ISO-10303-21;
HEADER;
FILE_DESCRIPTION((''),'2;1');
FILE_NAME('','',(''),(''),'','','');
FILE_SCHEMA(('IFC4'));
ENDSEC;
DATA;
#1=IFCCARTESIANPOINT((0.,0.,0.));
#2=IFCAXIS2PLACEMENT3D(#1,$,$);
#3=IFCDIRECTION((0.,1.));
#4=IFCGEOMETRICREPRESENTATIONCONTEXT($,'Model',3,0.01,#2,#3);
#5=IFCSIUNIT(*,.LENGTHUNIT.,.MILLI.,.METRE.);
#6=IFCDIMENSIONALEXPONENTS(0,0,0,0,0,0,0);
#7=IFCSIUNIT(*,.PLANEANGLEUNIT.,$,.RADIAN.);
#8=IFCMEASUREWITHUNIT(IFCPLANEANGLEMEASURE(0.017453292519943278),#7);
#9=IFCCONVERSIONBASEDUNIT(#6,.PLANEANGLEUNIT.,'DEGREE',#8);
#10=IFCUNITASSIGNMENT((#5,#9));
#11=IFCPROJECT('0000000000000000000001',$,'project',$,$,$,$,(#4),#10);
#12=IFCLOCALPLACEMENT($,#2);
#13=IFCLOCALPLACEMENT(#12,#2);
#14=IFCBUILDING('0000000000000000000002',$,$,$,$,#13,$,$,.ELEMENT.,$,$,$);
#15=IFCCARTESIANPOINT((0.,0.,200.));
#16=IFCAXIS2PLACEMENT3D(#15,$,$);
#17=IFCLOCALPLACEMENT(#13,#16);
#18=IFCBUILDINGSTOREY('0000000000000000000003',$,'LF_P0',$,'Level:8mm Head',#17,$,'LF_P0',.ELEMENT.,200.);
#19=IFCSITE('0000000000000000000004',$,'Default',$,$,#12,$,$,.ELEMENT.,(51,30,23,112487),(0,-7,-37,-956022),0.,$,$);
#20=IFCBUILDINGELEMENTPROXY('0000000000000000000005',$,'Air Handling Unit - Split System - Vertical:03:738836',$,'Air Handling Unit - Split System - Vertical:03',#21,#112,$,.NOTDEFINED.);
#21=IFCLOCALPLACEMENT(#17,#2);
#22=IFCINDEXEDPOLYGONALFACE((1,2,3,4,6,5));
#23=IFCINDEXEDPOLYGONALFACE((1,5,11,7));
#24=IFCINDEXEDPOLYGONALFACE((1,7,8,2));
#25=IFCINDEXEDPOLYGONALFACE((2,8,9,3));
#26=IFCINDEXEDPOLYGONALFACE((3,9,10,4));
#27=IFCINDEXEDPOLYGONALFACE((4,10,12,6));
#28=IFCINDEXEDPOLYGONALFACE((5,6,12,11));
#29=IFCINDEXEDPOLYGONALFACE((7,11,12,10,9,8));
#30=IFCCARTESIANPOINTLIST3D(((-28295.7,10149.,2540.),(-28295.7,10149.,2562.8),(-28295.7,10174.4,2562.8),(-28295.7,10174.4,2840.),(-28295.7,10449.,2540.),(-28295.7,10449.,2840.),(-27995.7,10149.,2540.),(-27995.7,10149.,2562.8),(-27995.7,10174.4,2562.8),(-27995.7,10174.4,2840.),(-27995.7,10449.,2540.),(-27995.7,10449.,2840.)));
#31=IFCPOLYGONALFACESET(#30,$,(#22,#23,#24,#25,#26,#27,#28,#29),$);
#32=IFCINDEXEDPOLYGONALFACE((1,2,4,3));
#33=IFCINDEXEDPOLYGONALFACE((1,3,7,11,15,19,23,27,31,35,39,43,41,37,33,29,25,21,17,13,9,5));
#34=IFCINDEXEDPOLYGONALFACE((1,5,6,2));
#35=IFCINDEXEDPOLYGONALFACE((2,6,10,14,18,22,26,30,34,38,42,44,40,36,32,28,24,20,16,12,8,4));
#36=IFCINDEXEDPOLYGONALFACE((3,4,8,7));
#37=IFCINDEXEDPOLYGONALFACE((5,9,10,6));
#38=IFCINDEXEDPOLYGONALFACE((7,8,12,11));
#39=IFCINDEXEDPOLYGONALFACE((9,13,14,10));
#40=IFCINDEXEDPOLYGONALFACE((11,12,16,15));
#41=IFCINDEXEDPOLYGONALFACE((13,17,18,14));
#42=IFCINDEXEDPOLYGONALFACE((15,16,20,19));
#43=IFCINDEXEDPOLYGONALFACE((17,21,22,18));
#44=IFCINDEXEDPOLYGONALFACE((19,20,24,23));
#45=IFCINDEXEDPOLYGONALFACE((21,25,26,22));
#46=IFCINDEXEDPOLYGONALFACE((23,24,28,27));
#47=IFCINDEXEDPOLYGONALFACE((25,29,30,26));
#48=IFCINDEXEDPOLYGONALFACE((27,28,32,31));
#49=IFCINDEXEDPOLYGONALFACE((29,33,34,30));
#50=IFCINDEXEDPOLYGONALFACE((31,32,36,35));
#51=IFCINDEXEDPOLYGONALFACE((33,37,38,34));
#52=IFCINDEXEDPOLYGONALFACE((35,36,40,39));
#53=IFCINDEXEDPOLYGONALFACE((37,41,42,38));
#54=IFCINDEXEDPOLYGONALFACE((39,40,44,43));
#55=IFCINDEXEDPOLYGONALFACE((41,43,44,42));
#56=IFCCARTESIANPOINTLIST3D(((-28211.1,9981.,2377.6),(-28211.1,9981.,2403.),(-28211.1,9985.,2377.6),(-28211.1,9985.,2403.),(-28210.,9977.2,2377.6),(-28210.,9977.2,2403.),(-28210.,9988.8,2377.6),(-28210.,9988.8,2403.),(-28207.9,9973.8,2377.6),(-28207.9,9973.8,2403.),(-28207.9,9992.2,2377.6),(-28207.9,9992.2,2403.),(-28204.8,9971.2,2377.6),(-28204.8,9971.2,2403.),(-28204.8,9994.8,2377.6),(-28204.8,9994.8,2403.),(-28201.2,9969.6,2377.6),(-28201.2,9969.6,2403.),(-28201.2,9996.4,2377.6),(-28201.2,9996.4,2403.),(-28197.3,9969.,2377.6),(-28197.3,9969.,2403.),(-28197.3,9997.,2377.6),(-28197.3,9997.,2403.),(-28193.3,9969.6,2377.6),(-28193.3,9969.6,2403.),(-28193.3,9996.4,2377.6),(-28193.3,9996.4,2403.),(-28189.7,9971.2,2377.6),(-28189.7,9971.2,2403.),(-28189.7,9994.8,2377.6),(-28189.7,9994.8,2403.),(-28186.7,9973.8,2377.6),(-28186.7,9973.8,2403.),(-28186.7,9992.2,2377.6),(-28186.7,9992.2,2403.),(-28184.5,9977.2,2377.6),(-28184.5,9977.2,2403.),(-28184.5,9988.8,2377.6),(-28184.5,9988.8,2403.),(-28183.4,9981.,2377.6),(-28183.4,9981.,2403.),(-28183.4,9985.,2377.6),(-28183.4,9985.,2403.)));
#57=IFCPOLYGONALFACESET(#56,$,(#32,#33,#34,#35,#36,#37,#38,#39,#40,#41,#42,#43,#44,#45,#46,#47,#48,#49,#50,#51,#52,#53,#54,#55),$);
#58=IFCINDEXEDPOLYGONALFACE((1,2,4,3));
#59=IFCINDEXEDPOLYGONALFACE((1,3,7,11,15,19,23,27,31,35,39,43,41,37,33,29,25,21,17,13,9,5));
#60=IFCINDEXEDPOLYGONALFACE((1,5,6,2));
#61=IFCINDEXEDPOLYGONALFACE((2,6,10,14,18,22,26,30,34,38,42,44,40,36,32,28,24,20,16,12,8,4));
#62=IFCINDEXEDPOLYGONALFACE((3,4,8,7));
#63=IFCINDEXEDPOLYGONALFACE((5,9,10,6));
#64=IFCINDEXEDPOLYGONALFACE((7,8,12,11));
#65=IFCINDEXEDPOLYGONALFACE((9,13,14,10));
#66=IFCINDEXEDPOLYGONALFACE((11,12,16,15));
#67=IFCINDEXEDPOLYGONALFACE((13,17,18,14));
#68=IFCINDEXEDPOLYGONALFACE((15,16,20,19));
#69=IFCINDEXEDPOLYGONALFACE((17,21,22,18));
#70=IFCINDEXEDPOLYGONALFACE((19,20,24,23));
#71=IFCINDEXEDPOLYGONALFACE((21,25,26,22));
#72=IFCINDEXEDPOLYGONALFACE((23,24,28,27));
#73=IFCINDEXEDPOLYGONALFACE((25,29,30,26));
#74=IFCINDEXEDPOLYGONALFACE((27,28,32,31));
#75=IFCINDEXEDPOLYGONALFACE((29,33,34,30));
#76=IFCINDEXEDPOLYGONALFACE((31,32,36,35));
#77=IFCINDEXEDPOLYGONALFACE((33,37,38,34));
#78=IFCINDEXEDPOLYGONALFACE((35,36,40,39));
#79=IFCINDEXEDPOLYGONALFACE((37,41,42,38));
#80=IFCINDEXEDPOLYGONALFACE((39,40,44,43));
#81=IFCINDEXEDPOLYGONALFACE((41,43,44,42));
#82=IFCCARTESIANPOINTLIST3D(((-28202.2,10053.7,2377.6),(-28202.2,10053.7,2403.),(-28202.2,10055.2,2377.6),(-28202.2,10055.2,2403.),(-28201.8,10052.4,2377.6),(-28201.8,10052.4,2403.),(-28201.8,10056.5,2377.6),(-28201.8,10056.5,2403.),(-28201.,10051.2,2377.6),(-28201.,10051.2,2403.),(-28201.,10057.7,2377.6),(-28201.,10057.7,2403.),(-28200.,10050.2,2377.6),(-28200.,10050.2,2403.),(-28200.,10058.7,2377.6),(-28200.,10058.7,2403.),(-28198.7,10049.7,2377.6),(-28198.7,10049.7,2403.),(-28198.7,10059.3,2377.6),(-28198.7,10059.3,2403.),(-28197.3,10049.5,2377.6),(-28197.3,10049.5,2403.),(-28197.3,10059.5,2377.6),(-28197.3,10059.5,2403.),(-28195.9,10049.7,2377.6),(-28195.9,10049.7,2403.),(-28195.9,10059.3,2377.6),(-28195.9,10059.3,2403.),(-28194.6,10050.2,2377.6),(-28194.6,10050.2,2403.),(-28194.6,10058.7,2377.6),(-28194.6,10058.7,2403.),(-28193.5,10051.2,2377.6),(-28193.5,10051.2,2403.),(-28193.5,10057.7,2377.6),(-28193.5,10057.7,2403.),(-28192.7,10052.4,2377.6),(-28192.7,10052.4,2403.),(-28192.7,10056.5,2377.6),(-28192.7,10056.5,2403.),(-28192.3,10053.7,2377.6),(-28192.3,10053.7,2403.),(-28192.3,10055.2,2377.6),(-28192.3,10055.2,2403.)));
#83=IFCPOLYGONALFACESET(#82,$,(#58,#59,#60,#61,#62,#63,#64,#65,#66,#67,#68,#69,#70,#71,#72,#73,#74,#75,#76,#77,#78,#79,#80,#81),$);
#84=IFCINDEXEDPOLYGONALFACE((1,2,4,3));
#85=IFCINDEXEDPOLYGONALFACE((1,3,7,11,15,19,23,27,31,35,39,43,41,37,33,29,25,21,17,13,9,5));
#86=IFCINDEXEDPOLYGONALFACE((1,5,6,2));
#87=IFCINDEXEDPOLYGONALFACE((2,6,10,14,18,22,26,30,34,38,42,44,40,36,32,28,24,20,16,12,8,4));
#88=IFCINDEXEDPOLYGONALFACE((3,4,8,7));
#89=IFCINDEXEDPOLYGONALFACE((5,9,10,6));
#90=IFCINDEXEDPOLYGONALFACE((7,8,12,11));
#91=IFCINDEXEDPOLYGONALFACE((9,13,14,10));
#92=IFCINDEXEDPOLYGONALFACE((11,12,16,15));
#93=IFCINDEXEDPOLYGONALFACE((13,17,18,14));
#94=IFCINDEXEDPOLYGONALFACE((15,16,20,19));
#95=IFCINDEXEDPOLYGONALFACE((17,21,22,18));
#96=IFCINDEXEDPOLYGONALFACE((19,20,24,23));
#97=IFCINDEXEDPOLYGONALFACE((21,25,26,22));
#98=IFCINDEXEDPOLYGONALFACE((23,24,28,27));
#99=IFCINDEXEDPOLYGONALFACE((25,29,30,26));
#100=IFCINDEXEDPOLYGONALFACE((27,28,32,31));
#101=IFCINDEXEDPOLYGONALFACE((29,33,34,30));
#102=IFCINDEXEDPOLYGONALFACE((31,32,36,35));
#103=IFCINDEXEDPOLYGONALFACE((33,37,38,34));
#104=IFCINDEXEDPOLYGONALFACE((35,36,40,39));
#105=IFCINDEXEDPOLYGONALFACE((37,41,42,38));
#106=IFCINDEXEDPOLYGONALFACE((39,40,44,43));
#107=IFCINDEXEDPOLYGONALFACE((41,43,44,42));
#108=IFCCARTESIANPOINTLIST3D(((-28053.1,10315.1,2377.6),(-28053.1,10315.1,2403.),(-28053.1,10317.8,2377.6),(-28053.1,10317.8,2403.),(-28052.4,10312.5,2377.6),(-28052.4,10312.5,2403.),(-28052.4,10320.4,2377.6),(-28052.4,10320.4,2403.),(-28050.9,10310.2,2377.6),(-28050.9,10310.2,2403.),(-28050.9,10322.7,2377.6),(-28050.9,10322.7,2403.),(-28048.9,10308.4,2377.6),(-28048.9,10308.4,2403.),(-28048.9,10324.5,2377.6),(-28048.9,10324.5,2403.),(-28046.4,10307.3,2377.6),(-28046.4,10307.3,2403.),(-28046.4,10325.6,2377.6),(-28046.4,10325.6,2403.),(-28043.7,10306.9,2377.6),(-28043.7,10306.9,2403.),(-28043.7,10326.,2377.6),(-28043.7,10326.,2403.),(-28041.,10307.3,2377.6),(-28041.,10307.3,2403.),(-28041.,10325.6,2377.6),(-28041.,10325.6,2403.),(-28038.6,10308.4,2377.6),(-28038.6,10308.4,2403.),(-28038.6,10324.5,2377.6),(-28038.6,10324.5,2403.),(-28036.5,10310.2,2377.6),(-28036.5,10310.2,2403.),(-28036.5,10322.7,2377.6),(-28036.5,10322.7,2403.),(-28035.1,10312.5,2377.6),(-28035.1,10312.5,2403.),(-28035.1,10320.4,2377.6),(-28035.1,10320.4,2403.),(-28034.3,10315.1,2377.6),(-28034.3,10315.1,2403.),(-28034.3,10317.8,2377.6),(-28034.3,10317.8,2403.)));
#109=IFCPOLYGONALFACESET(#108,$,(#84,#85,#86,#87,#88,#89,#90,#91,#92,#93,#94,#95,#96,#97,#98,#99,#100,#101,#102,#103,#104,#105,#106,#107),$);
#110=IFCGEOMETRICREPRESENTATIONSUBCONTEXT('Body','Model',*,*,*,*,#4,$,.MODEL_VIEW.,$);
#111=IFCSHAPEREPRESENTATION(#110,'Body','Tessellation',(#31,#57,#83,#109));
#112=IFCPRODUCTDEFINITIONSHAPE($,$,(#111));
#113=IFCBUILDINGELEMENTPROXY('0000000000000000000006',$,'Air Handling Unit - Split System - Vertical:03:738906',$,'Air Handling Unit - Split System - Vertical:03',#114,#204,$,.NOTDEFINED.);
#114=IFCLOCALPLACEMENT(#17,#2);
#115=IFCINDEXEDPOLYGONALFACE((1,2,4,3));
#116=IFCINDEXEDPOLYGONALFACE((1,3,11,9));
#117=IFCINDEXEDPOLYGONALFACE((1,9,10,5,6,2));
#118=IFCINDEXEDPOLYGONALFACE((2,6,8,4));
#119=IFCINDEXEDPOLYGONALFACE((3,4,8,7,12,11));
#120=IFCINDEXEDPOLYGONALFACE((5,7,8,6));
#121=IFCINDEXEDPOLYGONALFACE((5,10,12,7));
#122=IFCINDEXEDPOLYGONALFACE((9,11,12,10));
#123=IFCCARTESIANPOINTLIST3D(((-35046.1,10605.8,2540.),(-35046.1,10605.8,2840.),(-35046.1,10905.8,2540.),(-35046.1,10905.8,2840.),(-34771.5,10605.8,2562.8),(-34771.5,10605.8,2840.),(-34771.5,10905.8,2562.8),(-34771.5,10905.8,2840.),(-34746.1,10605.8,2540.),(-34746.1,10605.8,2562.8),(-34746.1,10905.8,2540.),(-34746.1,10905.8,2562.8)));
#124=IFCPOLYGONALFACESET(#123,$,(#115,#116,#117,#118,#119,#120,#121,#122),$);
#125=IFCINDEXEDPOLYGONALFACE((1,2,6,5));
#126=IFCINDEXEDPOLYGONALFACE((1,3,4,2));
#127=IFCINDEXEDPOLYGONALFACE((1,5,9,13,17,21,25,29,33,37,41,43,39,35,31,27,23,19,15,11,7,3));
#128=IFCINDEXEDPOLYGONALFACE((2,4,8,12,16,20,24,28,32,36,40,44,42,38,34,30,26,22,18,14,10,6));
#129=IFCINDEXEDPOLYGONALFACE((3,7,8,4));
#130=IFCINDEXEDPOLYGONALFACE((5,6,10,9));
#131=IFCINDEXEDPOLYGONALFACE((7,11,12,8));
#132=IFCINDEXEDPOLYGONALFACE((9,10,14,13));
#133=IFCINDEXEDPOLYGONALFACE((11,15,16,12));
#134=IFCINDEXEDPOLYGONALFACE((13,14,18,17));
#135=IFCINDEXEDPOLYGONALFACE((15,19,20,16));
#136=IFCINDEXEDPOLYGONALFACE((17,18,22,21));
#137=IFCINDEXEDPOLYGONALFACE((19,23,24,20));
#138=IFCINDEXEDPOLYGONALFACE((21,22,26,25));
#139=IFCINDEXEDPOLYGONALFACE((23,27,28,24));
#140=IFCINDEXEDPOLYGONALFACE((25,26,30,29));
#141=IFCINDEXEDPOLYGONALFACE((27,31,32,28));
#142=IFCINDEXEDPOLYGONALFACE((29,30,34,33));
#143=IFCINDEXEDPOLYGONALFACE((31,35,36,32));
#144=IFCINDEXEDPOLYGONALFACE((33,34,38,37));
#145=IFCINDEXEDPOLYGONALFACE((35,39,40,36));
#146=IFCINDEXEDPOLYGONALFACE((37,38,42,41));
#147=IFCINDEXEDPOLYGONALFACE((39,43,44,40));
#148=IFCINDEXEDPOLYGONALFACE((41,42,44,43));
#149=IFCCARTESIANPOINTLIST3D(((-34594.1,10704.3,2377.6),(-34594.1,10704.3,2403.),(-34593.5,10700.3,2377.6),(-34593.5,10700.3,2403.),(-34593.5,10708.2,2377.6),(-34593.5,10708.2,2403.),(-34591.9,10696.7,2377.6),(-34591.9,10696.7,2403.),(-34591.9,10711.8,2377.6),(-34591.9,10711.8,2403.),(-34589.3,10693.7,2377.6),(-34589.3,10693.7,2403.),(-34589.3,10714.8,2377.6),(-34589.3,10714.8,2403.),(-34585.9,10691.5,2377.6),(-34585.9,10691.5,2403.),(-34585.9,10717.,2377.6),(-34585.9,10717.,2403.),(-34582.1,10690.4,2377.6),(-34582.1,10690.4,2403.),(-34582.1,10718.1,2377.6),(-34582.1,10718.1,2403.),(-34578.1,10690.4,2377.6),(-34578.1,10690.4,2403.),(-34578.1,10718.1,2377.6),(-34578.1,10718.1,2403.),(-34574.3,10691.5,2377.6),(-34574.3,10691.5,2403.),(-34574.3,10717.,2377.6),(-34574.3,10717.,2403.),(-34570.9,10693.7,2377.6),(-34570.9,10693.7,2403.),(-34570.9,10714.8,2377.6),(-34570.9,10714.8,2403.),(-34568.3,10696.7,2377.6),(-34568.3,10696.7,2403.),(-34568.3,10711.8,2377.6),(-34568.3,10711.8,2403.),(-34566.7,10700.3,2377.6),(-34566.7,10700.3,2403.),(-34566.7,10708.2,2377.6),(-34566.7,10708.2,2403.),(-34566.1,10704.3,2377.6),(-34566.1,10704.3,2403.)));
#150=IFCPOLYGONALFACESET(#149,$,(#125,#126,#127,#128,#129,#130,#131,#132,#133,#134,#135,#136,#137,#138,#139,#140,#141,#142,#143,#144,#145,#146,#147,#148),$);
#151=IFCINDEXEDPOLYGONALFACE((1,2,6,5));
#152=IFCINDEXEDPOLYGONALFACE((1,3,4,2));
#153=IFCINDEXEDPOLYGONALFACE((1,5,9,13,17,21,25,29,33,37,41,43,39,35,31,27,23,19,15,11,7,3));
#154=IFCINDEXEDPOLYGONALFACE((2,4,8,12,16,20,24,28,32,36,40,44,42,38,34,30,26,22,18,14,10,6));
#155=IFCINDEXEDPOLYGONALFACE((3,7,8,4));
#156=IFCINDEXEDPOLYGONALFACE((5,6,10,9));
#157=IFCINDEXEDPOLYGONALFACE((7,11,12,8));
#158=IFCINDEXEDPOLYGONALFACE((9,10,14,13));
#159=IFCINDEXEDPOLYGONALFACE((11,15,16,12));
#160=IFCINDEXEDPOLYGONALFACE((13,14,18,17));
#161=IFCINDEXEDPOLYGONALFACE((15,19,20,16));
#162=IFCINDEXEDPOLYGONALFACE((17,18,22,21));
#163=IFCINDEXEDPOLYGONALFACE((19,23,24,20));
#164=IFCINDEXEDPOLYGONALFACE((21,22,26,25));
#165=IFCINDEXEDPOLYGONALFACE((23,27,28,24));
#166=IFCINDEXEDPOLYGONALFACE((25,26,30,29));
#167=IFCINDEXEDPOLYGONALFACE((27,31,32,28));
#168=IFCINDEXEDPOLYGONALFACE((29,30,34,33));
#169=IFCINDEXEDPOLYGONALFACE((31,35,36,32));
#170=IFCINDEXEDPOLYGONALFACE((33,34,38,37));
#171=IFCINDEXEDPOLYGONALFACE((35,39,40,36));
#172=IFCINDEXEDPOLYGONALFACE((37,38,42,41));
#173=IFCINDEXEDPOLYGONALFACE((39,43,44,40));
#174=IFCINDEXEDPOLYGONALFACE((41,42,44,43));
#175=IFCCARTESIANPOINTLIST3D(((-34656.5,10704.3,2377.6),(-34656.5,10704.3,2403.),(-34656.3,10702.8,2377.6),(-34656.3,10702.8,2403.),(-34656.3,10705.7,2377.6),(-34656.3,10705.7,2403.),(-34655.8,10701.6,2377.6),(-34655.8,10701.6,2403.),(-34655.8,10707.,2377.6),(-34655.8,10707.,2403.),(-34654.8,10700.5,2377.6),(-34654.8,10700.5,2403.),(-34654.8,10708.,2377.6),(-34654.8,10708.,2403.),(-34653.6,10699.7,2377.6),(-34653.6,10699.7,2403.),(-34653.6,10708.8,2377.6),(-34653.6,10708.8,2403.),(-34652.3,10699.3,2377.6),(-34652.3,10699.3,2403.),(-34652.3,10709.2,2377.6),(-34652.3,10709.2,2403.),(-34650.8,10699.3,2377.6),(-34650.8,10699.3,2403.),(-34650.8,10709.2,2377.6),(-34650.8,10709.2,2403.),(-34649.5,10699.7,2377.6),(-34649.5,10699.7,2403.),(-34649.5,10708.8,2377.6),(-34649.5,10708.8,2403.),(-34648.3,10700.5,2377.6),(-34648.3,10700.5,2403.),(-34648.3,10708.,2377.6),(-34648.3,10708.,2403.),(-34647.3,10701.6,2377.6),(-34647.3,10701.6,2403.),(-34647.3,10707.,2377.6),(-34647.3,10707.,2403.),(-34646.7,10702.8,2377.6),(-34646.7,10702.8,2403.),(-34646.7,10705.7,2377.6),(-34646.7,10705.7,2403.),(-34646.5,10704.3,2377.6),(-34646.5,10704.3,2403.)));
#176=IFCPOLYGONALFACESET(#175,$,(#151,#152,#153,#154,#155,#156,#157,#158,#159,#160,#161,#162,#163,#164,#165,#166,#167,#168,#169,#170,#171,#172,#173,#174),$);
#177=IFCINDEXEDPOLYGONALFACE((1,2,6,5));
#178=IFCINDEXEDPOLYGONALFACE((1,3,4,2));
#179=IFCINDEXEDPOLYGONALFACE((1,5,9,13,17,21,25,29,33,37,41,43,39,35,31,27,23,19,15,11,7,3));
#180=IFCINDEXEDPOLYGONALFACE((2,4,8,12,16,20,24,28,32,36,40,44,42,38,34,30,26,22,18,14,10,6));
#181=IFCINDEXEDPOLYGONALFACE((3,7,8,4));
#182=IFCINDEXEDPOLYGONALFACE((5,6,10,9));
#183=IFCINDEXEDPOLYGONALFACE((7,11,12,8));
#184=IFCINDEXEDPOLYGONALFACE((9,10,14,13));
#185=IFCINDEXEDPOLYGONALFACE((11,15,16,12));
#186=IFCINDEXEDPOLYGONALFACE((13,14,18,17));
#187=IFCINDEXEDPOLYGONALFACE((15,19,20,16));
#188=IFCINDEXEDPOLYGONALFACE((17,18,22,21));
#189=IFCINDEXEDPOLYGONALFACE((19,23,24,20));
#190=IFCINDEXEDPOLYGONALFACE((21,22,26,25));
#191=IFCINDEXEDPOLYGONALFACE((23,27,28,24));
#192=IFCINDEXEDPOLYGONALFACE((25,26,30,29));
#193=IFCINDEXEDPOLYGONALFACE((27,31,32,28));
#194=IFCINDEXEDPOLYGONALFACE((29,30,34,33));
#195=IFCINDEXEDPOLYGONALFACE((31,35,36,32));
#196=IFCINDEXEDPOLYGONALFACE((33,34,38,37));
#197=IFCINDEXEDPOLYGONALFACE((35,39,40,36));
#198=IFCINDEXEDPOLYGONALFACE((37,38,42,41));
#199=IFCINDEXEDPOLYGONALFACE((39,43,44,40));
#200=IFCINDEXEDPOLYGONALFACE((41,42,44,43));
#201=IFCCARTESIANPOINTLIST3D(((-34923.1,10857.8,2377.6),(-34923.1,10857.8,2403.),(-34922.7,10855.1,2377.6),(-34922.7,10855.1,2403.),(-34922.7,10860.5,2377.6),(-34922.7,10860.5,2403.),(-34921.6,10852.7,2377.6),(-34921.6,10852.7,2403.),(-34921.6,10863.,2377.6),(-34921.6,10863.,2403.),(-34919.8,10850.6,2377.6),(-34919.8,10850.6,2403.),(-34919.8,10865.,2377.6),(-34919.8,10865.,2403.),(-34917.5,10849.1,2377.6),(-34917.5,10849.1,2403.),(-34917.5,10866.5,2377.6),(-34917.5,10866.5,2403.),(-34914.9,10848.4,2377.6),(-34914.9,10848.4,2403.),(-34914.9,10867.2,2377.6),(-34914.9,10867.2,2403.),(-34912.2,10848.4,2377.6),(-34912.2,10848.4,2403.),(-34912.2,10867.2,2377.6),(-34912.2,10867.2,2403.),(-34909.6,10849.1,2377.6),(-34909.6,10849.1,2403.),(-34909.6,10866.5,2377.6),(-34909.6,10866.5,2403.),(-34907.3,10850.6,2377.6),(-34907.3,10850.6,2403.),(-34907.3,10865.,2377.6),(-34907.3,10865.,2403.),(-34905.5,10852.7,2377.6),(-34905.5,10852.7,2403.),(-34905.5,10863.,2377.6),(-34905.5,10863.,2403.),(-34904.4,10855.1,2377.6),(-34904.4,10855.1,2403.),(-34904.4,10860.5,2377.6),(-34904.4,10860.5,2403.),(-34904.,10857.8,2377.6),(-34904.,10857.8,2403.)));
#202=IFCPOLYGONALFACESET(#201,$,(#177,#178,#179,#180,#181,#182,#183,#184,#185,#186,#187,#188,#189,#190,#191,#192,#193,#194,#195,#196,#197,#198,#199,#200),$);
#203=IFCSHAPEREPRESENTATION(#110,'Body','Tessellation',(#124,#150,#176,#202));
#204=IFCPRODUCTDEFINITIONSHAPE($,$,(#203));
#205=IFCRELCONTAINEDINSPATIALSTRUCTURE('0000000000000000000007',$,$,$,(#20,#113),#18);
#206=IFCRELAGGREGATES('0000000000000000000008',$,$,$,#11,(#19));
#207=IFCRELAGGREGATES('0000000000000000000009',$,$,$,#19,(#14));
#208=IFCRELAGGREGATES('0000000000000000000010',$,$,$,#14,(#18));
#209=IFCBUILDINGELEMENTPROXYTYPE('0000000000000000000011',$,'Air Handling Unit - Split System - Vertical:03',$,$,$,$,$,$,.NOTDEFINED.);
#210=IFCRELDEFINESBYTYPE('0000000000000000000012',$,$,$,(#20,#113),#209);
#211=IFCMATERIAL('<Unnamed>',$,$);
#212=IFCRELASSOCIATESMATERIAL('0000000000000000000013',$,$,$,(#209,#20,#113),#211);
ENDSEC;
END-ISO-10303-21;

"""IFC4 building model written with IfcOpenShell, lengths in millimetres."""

from ifc_helpers import new_model, entity, si_unit, converted_unit, direction, frame, origin, place, context, subcontext, project, spatial, arc, indexed_curve, outline, extrude, source, transform, mapped, material, type_object, type_shapes, element, save


model = new_model("IFC4")

# Units and contexts
model_context = context("Model", 3, precision=0.01, world=origin(), true_north=direction((0.0, 1.0)))
body_context = subcontext(model_context, "Body", "Model", "MODEL_VIEW")
ifc_project = project(units=[si_unit("LENGTHUNIT", "METRE", prefix="MILLI"), converted_unit("PLANEANGLEUNIT", "DEGREE", entity("IfcPlaneAngleMeasure", 0.017453292519943278), si_unit("PLANEANGLEUNIT", "RADIAN"), dimensions=[0, 0, 0, 0, 0, 0, 0])], contexts=[model_context])

# Site, building, storey
site_placement = place(None, origin())
site = spatial("IfcSite", under=ifc_project, at=site_placement, Name="Default", CompositionType="ELEMENT", RefLatitude=(51, 30, 23, 112487), RefLongitude=(0, -7, -37, -956022), RefElevation=0.0)
building_placement = place(site_placement, origin())
building = spatial("IfcBuilding", under=site, at=building_placement, CompositionType="ELEMENT")
storey_placement = place(building_placement, frame((0.0, 0.0, 200.0)))
storey = spatial("IfcBuildingStorey", under=building, at=storey_placement, Name="LF_P0", ObjectType="Level:8mm Head", LongName="LF_P0", CompositionType="ELEMENT", Elevation=200.0)

# Shared definitions
ifc_material = material(Name="<Unnamed>")

# Building element proxies
building_element_proxy_type_1 = type_object("IfcBuildingElementProxyType", Name="Air Handling Unit - Split System - Vertical:03", PredefinedType="NOTDEFINED", material=ifc_material)
shared_shape_1 = source(origin(), body_context, "Body", "SweptSolid", [
    extrude(outline(indexed_curve([(-191.5, -107.6), (108.5, -107.6), (108.5, -84.8), (83.1, -84.8), (83.1, 192.4), (-191.5, 192.4), (-191.5, -107.6)], self_intersect=False)), frame((-150.0, 42.4, 191.5), z_axis=(1.0, 0.0, 0.0), x_axis=(0.0, 0.0, 1.0)), (0.0, 0.0, 1.0), 300.0),
    extrude(outline(indexed_curve([(-14.0, 0.0), (0.0, -14.0), (14.0, 0.0), (0.0, 14.0)], segments=[arc(1, 2, 3), arc(3, 4, 1)], self_intersect=False)), frame((51.6, 287.0, 466.0), z_axis=(0.0, 1.0, 0.0), x_axis=(0.0, 0.0, -1.0)), (0.0, 0.0, 1.0), 25.4),
    extrude(outline(indexed_curve([(-5.0, 0.0), (0.0, -5.0), (5.0, 0.0), (0.0, 5.0)], segments=[arc(1, 2, 3), arc(3, 4, 1)], self_intersect=False)), frame((51.6, 287.0, 394.6), z_axis=(0.0, 1.0, 0.0), x_axis=(0.0, 0.0, -1.0)), (0.0, 0.0, 1.0), 25.4),
    extrude(outline(indexed_curve([(-9.5, 0.0), (0.0, -9.5), (9.5, 0.0), (0.0, 9.5)], segments=[arc(1, 2, 3), arc(3, 4, 1)], self_intersect=False)), frame((-102.0, 287.0, 132.6), z_axis=(0.0, 1.0, 0.0), x_axis=(0.0, 0.0, -1.0)), (0.0, 0.0, 1.0), 25.4),
])
type_shapes(building_element_proxy_type_1, [shared_shape_1])
for number, where, z_axis, x_axis, name in (
    (1, (-28145.7, 10449.0, 2690.0), (0.0, -1.0, 0.0), (-1.0, 0.0, 0.0), "Air Handling Unit - Split System - Vertical:03:738836"),
    (2, (-35046.1, 10755.8, 2690.0), (1.0, 0.0, 0.0), (0.0, -1.0, 0.0), "Air Handling Unit - Split System - Vertical:03:738906"),
):
    element("IfcBuildingElementProxy", number, at=place(storey_placement, frame(where, z_axis=z_axis, x_axis=x_axis)), inside=storey, type_object=building_element_proxy_type_1, material=ifc_material, Name=name, ObjectType="Air Handling Unit - Split System - Vertical:03", PredefinedType="NOTDEFINED", context=body_context, shape_type="MappedRepresentation", body=[
        mapped(shared_shape_1, transform((0.0, 0.0, 0.0), scale=1.0)),
    ])

save(model, "model.ifc")
